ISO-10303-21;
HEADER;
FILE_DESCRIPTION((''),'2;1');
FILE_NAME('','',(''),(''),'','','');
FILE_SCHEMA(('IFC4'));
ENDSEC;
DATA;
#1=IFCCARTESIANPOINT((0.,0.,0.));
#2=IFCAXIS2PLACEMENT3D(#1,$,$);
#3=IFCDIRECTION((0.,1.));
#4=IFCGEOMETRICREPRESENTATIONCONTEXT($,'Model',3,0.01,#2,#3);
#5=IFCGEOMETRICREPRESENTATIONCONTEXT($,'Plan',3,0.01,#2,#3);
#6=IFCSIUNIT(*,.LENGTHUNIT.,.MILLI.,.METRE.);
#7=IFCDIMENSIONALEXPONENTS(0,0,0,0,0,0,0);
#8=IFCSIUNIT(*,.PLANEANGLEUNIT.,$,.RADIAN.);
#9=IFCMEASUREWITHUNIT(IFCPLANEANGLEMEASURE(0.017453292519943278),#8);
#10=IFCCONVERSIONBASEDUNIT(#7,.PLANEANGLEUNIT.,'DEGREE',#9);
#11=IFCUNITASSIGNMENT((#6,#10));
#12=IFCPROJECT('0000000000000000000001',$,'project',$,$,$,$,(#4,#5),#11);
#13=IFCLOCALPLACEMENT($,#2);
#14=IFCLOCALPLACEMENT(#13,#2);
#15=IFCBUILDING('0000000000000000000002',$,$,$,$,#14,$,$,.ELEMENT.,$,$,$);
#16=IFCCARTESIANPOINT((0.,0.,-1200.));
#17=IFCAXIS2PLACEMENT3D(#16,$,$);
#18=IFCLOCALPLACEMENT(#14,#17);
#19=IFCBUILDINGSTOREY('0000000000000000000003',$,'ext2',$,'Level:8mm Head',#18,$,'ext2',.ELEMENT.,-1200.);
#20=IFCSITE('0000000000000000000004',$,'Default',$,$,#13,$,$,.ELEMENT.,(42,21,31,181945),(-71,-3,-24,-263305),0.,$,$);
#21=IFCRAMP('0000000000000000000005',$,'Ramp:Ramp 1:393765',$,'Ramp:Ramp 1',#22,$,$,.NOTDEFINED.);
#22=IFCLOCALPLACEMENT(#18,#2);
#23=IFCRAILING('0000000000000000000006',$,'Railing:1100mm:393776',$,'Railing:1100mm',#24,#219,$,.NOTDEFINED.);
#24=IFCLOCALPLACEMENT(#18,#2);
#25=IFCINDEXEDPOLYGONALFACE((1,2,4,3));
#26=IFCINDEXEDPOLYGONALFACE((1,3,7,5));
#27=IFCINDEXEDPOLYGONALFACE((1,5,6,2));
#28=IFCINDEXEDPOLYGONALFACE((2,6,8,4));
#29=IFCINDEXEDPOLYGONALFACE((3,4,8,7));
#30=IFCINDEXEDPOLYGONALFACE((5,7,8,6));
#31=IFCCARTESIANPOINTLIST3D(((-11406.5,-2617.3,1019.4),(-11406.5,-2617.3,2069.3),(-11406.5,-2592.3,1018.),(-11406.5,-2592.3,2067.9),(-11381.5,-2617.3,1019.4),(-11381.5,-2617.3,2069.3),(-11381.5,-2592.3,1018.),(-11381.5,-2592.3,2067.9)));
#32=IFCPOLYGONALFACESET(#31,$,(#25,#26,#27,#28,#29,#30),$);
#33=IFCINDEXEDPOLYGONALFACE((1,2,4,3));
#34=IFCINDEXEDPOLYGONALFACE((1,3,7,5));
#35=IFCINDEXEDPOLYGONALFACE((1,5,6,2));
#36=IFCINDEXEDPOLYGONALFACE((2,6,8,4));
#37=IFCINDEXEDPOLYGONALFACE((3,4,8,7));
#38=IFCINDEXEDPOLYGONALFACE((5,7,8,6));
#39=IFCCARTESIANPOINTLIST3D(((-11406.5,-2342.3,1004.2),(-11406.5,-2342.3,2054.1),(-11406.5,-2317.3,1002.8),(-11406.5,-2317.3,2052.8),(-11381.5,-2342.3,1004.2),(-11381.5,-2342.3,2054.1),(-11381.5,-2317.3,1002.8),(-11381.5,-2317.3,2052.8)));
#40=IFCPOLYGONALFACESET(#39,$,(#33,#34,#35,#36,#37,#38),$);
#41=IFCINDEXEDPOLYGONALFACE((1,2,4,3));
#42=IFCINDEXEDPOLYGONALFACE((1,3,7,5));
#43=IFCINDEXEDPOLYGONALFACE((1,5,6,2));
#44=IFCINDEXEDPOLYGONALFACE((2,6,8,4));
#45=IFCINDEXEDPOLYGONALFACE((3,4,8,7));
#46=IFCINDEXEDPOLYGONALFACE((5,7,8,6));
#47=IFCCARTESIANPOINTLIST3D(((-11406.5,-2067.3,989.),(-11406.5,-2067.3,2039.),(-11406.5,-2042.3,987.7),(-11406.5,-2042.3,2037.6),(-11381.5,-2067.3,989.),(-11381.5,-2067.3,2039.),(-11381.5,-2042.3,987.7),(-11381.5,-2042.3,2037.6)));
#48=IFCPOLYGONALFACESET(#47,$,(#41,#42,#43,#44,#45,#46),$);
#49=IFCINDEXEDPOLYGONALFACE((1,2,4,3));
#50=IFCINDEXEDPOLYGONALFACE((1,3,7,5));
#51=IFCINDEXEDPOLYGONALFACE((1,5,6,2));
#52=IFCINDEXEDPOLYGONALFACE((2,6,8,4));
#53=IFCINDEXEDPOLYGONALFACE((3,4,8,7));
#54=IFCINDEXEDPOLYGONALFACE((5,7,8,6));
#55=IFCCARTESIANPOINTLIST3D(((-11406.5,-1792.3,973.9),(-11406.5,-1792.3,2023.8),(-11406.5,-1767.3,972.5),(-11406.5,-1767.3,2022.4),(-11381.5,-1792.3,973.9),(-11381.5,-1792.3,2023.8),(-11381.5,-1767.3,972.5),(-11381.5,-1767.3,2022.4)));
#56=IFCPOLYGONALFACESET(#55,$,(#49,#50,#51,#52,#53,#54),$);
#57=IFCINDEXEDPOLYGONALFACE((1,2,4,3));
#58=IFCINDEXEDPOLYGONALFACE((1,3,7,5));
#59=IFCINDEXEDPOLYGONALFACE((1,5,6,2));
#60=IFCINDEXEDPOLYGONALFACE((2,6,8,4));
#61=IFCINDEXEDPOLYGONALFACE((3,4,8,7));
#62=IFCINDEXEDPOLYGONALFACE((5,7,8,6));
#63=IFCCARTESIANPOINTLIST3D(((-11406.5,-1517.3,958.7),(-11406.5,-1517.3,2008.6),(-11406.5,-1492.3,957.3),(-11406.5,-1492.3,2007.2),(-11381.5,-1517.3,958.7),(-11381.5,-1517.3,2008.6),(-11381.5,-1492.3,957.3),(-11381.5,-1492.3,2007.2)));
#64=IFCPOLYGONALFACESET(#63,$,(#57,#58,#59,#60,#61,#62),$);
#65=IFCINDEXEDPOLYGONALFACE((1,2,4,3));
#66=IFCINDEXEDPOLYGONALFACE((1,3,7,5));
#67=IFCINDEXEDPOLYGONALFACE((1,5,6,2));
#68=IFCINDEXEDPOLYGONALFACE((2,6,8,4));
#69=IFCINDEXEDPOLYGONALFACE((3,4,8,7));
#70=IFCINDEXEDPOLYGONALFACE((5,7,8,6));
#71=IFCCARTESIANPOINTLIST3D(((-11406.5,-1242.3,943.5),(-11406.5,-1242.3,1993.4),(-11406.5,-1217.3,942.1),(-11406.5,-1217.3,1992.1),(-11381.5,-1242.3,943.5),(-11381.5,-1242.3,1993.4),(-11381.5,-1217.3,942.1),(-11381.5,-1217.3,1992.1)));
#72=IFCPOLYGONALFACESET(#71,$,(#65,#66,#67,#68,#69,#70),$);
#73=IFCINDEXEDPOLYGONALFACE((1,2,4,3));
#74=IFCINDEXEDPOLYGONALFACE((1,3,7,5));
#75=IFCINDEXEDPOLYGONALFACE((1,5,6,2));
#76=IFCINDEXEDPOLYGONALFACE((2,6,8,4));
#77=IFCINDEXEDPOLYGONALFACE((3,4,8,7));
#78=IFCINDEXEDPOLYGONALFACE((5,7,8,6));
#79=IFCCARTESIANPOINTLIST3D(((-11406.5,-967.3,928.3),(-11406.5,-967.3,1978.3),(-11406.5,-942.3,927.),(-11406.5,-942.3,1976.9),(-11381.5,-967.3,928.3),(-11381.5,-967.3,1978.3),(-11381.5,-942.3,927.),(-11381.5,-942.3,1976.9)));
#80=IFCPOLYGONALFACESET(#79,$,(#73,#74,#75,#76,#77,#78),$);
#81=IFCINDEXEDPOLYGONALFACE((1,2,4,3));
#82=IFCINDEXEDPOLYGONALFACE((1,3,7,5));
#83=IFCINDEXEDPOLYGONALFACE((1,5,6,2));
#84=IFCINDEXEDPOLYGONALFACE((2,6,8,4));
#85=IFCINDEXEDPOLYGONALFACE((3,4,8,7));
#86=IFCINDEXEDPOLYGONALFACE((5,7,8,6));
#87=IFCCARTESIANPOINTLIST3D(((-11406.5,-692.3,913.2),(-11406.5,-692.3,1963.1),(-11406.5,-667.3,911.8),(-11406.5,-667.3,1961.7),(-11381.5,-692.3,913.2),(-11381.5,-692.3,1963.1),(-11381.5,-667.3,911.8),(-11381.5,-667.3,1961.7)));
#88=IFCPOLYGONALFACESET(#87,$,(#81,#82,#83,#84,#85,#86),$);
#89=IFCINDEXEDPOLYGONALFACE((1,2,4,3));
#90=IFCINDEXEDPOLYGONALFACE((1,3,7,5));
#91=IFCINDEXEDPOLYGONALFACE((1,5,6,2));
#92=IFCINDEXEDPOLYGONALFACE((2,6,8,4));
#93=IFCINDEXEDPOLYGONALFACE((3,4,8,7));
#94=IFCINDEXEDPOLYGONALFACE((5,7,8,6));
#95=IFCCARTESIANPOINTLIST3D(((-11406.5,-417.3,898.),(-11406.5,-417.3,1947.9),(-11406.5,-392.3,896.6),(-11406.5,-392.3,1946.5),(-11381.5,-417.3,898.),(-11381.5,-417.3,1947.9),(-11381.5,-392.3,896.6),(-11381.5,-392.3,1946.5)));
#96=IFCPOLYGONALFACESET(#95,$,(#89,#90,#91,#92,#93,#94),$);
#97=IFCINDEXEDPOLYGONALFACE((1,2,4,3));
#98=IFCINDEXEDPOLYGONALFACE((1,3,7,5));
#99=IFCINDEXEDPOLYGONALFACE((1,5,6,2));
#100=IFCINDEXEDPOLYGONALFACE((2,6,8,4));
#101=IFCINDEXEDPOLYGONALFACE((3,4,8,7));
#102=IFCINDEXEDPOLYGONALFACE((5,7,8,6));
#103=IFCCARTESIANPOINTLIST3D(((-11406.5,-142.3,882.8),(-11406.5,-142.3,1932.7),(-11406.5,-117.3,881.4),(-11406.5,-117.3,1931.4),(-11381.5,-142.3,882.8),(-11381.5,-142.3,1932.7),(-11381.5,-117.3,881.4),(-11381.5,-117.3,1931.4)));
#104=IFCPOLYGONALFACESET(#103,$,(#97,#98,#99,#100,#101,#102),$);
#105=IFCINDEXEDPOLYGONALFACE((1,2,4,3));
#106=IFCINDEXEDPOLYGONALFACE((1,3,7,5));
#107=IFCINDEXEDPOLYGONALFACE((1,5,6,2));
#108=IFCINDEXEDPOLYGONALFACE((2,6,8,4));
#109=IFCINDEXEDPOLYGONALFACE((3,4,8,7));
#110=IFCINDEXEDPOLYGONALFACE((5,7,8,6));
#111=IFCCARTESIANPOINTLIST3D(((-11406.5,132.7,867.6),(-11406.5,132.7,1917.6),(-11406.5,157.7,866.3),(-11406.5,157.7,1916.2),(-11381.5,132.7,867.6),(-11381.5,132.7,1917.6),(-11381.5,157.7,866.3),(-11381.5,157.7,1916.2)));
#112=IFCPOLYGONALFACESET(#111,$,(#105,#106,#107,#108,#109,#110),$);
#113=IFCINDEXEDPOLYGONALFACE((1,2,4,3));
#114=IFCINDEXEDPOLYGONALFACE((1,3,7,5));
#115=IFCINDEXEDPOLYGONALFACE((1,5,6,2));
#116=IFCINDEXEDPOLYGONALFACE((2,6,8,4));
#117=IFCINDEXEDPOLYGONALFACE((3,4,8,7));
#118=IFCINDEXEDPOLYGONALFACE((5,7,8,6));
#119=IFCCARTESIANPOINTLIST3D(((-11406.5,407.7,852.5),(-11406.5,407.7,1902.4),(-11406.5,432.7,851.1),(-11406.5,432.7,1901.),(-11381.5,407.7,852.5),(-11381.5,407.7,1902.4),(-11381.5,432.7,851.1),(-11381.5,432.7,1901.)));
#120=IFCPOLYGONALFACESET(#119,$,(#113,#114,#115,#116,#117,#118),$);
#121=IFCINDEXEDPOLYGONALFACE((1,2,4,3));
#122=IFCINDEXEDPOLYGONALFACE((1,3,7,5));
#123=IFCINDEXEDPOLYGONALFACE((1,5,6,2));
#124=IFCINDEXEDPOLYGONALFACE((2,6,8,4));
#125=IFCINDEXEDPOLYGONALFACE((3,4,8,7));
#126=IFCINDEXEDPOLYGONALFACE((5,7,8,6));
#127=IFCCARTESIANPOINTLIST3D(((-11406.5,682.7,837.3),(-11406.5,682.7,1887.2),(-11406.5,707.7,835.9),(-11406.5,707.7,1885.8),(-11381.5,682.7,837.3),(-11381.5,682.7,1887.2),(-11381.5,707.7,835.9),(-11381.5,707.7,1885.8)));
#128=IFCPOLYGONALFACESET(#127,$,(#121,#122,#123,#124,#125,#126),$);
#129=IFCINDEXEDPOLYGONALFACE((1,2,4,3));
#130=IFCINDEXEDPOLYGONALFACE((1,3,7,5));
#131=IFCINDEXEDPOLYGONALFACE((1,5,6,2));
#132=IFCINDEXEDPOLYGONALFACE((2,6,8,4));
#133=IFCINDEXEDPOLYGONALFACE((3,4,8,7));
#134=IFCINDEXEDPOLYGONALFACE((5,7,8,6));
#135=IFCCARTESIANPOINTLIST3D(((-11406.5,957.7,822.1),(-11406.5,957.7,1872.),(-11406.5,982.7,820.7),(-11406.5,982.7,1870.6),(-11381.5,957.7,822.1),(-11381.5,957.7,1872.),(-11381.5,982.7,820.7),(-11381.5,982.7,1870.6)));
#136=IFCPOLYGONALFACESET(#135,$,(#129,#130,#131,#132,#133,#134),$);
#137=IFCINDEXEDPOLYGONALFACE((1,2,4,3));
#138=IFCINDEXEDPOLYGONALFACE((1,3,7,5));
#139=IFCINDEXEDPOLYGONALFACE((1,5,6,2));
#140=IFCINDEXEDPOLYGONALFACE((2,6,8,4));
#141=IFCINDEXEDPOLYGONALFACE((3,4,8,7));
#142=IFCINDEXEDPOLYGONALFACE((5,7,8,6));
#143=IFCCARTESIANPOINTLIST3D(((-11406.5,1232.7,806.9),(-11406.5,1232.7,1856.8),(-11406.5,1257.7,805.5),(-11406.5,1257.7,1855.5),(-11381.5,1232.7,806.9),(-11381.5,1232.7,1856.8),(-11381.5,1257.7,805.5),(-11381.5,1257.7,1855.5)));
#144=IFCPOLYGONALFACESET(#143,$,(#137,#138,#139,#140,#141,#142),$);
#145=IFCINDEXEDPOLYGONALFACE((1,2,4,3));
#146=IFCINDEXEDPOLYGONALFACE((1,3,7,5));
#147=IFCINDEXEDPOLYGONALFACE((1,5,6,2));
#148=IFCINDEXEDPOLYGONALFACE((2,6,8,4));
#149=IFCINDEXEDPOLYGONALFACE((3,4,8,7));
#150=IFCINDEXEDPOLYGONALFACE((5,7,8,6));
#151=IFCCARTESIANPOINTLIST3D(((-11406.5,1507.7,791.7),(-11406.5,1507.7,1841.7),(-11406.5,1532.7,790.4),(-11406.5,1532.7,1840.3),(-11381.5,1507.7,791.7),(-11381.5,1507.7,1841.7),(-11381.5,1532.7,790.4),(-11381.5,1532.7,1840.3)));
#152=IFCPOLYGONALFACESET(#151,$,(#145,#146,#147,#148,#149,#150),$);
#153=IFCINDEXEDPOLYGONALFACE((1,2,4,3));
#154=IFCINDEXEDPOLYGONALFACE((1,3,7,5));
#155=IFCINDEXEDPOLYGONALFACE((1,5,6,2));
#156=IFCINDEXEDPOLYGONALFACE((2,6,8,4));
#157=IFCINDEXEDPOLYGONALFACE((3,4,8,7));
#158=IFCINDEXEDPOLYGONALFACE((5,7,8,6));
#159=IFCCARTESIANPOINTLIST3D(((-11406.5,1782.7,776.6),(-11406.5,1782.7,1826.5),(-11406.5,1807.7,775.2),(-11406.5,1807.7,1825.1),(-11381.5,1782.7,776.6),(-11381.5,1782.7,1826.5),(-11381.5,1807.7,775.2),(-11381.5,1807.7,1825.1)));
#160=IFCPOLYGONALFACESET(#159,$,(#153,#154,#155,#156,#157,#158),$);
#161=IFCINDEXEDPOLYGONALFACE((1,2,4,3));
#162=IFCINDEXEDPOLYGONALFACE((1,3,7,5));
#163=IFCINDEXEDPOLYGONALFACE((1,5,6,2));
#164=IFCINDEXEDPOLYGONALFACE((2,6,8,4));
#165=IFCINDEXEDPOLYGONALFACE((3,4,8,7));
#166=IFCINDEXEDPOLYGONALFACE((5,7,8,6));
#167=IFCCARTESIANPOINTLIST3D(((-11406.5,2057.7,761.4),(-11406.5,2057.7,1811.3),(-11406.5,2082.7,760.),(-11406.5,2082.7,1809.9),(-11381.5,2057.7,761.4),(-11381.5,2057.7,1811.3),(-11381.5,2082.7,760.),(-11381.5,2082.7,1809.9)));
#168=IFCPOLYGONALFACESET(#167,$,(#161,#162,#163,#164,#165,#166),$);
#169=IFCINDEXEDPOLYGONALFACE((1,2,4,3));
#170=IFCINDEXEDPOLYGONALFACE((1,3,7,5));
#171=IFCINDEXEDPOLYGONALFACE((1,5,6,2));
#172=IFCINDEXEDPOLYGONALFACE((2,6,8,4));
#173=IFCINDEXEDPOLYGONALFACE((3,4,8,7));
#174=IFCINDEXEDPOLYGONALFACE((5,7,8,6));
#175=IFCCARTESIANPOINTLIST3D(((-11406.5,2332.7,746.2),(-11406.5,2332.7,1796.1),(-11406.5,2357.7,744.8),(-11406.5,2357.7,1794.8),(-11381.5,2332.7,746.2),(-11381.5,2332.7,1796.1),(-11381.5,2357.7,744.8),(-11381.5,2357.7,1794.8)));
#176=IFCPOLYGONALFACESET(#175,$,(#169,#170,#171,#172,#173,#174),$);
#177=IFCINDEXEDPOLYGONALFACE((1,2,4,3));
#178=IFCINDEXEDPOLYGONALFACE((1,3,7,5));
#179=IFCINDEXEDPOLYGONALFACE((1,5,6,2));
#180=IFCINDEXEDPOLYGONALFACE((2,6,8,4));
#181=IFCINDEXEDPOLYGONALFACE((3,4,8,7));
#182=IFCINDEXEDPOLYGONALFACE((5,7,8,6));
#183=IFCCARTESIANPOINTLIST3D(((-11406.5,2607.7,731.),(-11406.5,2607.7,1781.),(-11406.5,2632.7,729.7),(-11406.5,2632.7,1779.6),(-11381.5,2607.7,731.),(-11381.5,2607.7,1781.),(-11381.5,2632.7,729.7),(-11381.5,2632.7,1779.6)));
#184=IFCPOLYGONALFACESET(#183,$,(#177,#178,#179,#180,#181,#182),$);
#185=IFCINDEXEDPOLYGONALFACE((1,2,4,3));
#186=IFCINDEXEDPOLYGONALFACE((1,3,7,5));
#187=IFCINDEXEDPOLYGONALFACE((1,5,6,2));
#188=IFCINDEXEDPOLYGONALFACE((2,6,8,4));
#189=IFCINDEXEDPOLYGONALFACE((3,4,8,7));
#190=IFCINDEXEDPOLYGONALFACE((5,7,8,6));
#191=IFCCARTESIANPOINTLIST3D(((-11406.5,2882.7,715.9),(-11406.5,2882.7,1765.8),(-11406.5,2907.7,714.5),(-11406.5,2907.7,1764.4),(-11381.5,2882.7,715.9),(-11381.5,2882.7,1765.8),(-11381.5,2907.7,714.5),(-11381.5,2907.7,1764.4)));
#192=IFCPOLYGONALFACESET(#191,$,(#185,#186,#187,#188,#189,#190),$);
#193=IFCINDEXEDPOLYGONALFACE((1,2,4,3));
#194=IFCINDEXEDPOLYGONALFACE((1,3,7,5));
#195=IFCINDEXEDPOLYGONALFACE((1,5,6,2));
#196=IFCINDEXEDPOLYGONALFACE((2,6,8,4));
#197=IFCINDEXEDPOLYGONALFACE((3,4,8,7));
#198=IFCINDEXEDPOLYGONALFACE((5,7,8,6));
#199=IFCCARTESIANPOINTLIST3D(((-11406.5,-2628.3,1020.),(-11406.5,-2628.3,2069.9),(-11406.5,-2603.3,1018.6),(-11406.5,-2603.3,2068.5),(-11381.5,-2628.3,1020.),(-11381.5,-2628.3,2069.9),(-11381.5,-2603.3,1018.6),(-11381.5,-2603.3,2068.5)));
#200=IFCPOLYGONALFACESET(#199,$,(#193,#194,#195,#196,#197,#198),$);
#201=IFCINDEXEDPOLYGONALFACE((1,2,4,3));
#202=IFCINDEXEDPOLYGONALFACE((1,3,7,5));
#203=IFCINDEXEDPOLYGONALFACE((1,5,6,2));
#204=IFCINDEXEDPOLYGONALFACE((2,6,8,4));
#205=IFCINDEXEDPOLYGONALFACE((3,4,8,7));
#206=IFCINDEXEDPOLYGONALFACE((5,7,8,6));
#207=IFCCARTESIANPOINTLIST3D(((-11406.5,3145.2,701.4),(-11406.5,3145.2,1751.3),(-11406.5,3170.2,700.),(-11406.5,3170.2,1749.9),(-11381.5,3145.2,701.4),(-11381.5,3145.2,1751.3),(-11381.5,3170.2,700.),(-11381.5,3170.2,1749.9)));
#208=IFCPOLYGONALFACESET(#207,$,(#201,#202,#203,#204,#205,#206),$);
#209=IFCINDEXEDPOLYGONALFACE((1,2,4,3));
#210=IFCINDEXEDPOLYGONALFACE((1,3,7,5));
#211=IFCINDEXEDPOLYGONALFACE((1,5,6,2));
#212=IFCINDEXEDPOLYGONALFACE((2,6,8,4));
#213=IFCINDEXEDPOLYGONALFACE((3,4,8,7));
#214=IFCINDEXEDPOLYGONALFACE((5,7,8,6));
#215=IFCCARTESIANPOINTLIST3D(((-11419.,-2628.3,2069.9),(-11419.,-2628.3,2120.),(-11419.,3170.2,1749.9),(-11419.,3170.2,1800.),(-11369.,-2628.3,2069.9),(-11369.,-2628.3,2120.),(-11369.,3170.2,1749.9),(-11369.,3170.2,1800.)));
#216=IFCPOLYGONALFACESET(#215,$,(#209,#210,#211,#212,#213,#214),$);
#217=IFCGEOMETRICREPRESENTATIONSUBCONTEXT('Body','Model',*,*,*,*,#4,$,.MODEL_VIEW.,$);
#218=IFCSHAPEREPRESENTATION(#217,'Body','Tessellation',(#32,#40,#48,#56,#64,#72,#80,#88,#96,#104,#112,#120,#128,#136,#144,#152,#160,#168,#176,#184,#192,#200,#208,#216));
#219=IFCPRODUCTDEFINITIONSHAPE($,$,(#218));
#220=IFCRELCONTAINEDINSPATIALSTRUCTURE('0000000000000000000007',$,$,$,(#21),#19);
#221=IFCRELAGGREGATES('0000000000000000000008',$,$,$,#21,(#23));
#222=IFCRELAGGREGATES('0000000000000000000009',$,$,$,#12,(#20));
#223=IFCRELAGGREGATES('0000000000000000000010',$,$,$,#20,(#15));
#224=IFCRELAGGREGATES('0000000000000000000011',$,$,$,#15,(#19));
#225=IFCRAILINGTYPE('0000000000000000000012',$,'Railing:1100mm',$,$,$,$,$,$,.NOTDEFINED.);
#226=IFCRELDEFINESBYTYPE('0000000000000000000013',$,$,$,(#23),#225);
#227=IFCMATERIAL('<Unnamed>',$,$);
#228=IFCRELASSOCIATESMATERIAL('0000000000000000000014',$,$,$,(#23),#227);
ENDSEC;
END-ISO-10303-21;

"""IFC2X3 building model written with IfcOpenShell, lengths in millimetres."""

from ifc_helpers import new_model, entity, si_unit, converted_unit, direction, frame, origin, place, context, subcontext, project, spatial, polyline, outline, extrude, material, type_object, element, aggregate, save


model = new_model("IFC2X3")

# Units and contexts
model_context = context("Model", 3, precision=0.01, world=origin(), true_north=direction((0.0, 1.0)))
plan_context = context("Plan", 3, precision=0.01, world=origin(), true_north=direction((0.0, 1.0)))
body_context = subcontext(model_context, "Body", "Model", "MODEL_VIEW")
ifc_project = project(units=[si_unit("LENGTHUNIT", "METRE", prefix="MILLI"), converted_unit("PLANEANGLEUNIT", "DEGREE", entity("IfcPlaneAngleMeasure", 0.017453292519943278), si_unit("PLANEANGLEUNIT", "RADIAN"), dimensions=[0, 0, 0, 0, 0, 0, 0])], contexts=[model_context, plan_context])

# Site, building, storey
site_placement = place(None, origin())
site = spatial("IfcSite", under=ifc_project, at=site_placement, Name="Default", CompositionType="ELEMENT", RefLatitude=(42, 21, 31, 181945), RefLongitude=(-71, -3, -24, -263305), RefElevation=0.0)
building_placement = place(site_placement, origin())
building = spatial("IfcBuilding", under=site, at=building_placement, CompositionType="ELEMENT")
storey_placement = place(building_placement, frame((0.0, 0.0, -1200.0)))
storey = spatial("IfcBuildingStorey", under=building, at=storey_placement, Name="ext2", ObjectType="Level:8mm Head", LongName="ext2", CompositionType="ELEMENT", Elevation=-1200.0)

# Ramp, railing
ramp_placement = place(storey_placement, origin())
ramp = element("IfcRamp", 1, at=ramp_placement, inside=storey, Name="Ramp:Ramp 1:393765", ObjectType="Ramp:Ramp 1", ShapeType="NOTDEFINED")
ifc_material = material(Name="<Unnamed>")
railing_type = type_object("IfcRailingType", Name="Railing:1100mm", PredefinedType="NOTDEFINED")
railing_1_placement = place(ramp_placement, frame((-11419.0, -2628.3, 700.0)))
railing_1 = element("IfcRailing", 2, at=railing_1_placement, type_object=railing_type, material=ifc_material, Name="Railing:1100mm:393776", ObjectType="Railing:1100mm", PredefinedType="NOTDEFINED", context=body_context, shape_type="SweptSolid", body=[
    extrude(outline(polyline([(-525.7, -12.5), (524.3, -12.5), (525.7, 12.5), (-524.3, 12.5), (-525.7, -12.5)])), frame((12.5, 23.5, 843.7), z_axis=(1.0, 0.0, 0.0), x_axis=(0.0, 0.0, 1.0)), (0.0, 0.0, 1.0), 25.0),
    extrude(outline(polyline([(-525.7, -12.5), (524.3, -12.5), (525.7, 12.5), (-524.3, 12.5), (-525.7, -12.5)])), frame((12.5, 298.5, 828.5), z_axis=(1.0, 0.0, 0.0), x_axis=(0.0, 0.0, 1.0)), (0.0, 0.0, 1.0), 25.0),
    extrude(outline(polyline([(-525.7, -12.5), (524.3, -12.5), (525.7, 12.5), (-524.3, 12.5), (-525.7, -12.5)])), frame((12.5, 573.5, 813.3), z_axis=(1.0, 0.0, 0.0), x_axis=(0.0, 0.0, 1.0)), (0.0, 0.0, 1.0), 25.0),
    extrude(outline(polyline([(-525.7, -12.5), (524.3, -12.5), (525.7, 12.5), (-524.3, 12.5), (-525.7, -12.5)])), frame((12.5, 848.5, 798.1), z_axis=(1.0, 0.0, 0.0), x_axis=(0.0, 0.0, 1.0)), (0.0, 0.0, 1.0), 25.0),
    extrude(outline(polyline([(-525.7, -12.5), (524.3, -12.5), (525.7, 12.5), (-524.3, 12.5), (-525.7, -12.5)])), frame((12.5, 1123.5, 783.0), z_axis=(1.0, 0.0, 0.0), x_axis=(0.0, 0.0, 1.0)), (0.0, 0.0, 1.0), 25.0),
    extrude(outline(polyline([(-525.7, -12.5), (524.3, -12.5), (525.7, 12.5), (-524.3, 12.5), (-525.7, -12.5)])), frame((12.5, 1398.5, 767.8), z_axis=(1.0, 0.0, 0.0), x_axis=(0.0, 0.0, 1.0)), (0.0, 0.0, 1.0), 25.0),
    extrude(outline(polyline([(-525.7, -12.5), (524.3, -12.5), (525.7, 12.5), (-524.3, 12.5), (-525.7, -12.5)])), frame((12.5, 1673.5, 752.6), z_axis=(1.0, 0.0, 0.0), x_axis=(0.0, 0.0, 1.0)), (0.0, 0.0, 1.0), 25.0),
    extrude(outline(polyline([(-525.7, -12.5), (524.3, -12.5), (525.7, 12.5), (-524.3, 12.5), (-525.7, -12.5)])), frame((12.5, 1948.5, 737.4), z_axis=(1.0, 0.0, 0.0), x_axis=(0.0, 0.0, 1.0)), (0.0, 0.0, 1.0), 25.0),
    extrude(outline(polyline([(-525.7, -12.5), (524.3, -12.5), (525.7, 12.5), (-524.3, 12.5), (-525.7, -12.5)])), frame((12.5, 2223.5, 722.3), z_axis=(1.0, 0.0, 0.0), x_axis=(0.0, 0.0, 1.0)), (0.0, 0.0, 1.0), 25.0),
    extrude(outline(polyline([(-525.7, -12.5), (524.3, -12.5), (525.7, 12.5), (-524.3, 12.5), (-525.7, -12.5)])), frame((12.5, 2498.5, 707.1), z_axis=(1.0, 0.0, 0.0), x_axis=(0.0, 0.0, 1.0)), (0.0, 0.0, 1.0), 25.0),
    extrude(outline(polyline([(-525.7, -12.5), (524.3, -12.5), (525.7, 12.5), (-524.3, 12.5), (-525.7, -12.5)])), frame((12.5, 2773.5, 691.9), z_axis=(1.0, 0.0, 0.0), x_axis=(0.0, 0.0, 1.0)), (0.0, 0.0, 1.0), 25.0),
    extrude(outline(polyline([(-525.7, -12.5), (524.3, -12.5), (525.7, 12.5), (-524.3, 12.5), (-525.7, -12.5)])), frame((12.5, 3048.5, 676.7), z_axis=(1.0, 0.0, 0.0), x_axis=(0.0, 0.0, 1.0)), (0.0, 0.0, 1.0), 25.0),
    extrude(outline(polyline([(-525.7, -12.5), (524.3, -12.5), (525.7, 12.5), (-524.3, 12.5), (-525.7, -12.5)])), frame((12.5, 3323.5, 661.5), z_axis=(1.0, 0.0, 0.0), x_axis=(0.0, 0.0, 1.0)), (0.0, 0.0, 1.0), 25.0),
    extrude(outline(polyline([(-525.7, -12.5), (524.3, -12.5), (525.7, 12.5), (-524.3, 12.5), (-525.7, -12.5)])), frame((12.5, 3598.5, 646.4), z_axis=(1.0, 0.0, 0.0), x_axis=(0.0, 0.0, 1.0)), (0.0, 0.0, 1.0), 25.0),
    extrude(outline(polyline([(-525.7, -12.5), (524.3, -12.5), (525.7, 12.5), (-524.3, 12.5), (-525.7, -12.5)])), frame((12.5, 3873.5, 631.2), z_axis=(1.0, 0.0, 0.0), x_axis=(0.0, 0.0, 1.0)), (0.0, 0.0, 1.0), 25.0),
    extrude(outline(polyline([(-525.7, -12.5), (524.3, -12.5), (525.7, 12.5), (-524.3, 12.5), (-525.7, -12.5)])), frame((12.5, 4148.5, 616.0), z_axis=(1.0, 0.0, 0.0), x_axis=(0.0, 0.0, 1.0)), (0.0, 0.0, 1.0), 25.0),
    extrude(outline(polyline([(-525.7, -12.5), (524.3, -12.5), (525.7, 12.5), (-524.3, 12.5), (-525.7, -12.5)])), frame((12.5, 4423.5, 600.8), z_axis=(1.0, 0.0, 0.0), x_axis=(0.0, 0.0, 1.0)), (0.0, 0.0, 1.0), 25.0),
    extrude(outline(polyline([(-525.7, -12.5), (524.3, -12.5), (525.7, 12.5), (-524.3, 12.5), (-525.7, -12.5)])), frame((12.5, 4698.5, 585.7), z_axis=(1.0, 0.0, 0.0), x_axis=(0.0, 0.0, 1.0)), (0.0, 0.0, 1.0), 25.0),
    extrude(outline(polyline([(-525.7, -12.5), (524.3, -12.5), (525.7, 12.5), (-524.3, 12.5), (-525.7, -12.5)])), frame((12.5, 4973.5, 570.5), z_axis=(1.0, 0.0, 0.0), x_axis=(0.0, 0.0, 1.0)), (0.0, 0.0, 1.0), 25.0),
    extrude(outline(polyline([(-525.7, -12.5), (524.3, -12.5), (525.7, 12.5), (-524.3, 12.5), (-525.7, -12.5)])), frame((12.5, 5248.5, 555.3), z_axis=(1.0, 0.0, 0.0), x_axis=(0.0, 0.0, 1.0)), (0.0, 0.0, 1.0), 25.0),
    extrude(outline(polyline([(-525.7, -12.5), (524.3, -12.5), (525.7, 12.5), (-524.3, 12.5), (-525.7, -12.5)])), frame((12.5, 5523.5, 540.1), z_axis=(1.0, 0.0, 0.0), x_axis=(0.0, 0.0, 1.0)), (0.0, 0.0, 1.0), 25.0),
    extrude(outline(polyline([(-525.7, -12.5), (524.3, -12.5), (525.7, 12.5), (-524.3, 12.5), (-525.7, -12.5)])), frame((12.5, 12.5, 844.3), z_axis=(1.0, 0.0, 0.0), x_axis=(0.0, 0.0, 1.0)), (0.0, 0.0, 1.0), 25.0),
    extrude(outline(polyline([(-525.7, -12.5), (524.3, -12.5), (525.7, 12.5), (-524.3, 12.5), (-525.7, -12.5)])), frame((12.5, 5786.0, 525.7), z_axis=(1.0, 0.0, 0.0), x_axis=(0.0, 0.0, 1.0)), (0.0, 0.0, 1.0), 25.0),
    extrude(outline(polyline([(-2902.3, -25.0), (2905.0, -25.0), (2902.3, 25.0), (-2905.0, 25.0), (-2902.3, -25.0)])), frame((0.0, 2899.2, 1235.0), z_axis=(1.0, 0.0, 0.0), x_axis=(0.0, -0.998481, 0.055103)), (0.0, 0.0, 1.0), 50.0),
])
aggregate(ramp, [railing_1])

save(model, "model.ifc")
